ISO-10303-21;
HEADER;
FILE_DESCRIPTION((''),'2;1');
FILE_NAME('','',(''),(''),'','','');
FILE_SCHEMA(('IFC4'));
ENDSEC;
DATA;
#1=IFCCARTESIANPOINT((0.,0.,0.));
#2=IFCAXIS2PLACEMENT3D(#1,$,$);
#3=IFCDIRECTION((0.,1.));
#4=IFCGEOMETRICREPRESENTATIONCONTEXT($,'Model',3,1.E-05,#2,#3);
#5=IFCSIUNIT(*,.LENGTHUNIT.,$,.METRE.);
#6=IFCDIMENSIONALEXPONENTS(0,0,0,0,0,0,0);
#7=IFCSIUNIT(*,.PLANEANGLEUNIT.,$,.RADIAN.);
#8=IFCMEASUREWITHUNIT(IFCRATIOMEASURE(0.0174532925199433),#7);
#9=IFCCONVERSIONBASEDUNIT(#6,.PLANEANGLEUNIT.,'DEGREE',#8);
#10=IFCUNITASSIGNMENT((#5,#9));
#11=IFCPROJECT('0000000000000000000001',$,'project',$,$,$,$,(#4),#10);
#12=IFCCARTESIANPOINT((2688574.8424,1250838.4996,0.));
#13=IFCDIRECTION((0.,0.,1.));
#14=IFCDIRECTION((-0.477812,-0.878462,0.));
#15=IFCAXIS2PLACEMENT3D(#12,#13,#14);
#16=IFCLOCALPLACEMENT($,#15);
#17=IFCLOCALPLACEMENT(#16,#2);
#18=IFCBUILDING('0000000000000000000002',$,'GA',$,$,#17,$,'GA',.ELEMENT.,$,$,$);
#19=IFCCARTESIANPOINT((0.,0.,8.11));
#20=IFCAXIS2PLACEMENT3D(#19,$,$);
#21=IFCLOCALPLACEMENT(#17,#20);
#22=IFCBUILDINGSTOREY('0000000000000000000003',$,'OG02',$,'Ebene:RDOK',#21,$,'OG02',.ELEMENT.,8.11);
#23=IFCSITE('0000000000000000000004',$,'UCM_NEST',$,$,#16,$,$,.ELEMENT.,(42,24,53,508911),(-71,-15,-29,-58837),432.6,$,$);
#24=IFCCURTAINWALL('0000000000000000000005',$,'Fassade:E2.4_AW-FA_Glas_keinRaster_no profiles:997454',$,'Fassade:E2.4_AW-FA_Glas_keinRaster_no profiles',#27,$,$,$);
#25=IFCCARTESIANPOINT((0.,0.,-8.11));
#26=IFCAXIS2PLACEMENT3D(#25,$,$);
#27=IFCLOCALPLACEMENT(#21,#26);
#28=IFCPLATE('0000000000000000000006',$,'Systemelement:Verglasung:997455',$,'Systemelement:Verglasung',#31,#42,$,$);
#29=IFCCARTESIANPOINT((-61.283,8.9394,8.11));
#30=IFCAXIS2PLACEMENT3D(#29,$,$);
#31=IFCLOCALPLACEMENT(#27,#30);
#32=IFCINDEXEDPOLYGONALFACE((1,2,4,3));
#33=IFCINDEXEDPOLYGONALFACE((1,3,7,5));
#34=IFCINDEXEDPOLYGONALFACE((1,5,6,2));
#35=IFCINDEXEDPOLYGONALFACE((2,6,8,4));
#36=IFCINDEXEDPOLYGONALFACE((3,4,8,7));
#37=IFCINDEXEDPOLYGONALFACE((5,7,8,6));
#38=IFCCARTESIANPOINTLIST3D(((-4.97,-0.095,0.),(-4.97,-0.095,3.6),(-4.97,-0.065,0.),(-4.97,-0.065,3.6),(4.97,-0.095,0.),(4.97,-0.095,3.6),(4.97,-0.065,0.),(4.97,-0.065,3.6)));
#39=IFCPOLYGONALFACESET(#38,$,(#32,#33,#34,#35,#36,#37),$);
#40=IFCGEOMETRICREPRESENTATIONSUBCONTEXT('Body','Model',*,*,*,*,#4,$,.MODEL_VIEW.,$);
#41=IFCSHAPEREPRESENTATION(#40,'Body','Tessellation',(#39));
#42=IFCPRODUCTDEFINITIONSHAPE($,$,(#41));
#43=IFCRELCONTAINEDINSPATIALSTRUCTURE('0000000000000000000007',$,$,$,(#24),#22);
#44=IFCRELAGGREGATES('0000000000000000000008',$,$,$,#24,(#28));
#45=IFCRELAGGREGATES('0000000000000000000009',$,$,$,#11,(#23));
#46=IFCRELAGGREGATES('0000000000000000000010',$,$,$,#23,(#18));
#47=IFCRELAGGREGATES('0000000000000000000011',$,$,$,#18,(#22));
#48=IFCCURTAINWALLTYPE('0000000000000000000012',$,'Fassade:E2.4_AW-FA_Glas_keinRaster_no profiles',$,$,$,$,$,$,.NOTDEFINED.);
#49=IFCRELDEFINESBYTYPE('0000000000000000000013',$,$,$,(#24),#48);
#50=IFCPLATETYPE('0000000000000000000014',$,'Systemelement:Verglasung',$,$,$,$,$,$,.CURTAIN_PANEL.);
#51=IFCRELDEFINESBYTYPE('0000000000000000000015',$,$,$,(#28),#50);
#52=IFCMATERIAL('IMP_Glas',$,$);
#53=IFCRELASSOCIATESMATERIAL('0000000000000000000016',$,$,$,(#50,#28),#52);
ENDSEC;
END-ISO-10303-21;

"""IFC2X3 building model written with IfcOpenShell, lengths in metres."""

from ifc_helpers import new_model, entity, si_unit, converted_unit, direction, frame, frame_2d, origin, place, context, subcontext, project, spatial, rectangle, extrude, source, transform, mapped, material, type_object, type_shapes, element, aggregate, save


model = new_model("IFC2X3")

# Units and contexts
model_context = context("Model", 3, precision=1e-05, world=origin(), true_north=direction((0.0, 1.0)))
body_context = subcontext(model_context, "Body", "Model", "MODEL_VIEW")
ifc_project = project(units=[si_unit("LENGTHUNIT", "METRE"), converted_unit("PLANEANGLEUNIT", "DEGREE", entity("IfcRatioMeasure", 0.0174532925199433), si_unit("PLANEANGLEUNIT", "RADIAN"), dimensions=[0, 0, 0, 0, 0, 0, 0])], contexts=[model_context])

# Site, building, storey
site_placement = place(None, frame((2688574.8424, 1250838.4996, 0.0), z_axis=(0.0, 0.0, 1.0), x_axis=(-0.477812, -0.878462, 0.0)))
site = spatial("IfcSite", under=ifc_project, at=site_placement, Name="UCM_NEST", CompositionType="ELEMENT", RefLatitude=(42, 24, 53, 508911), RefLongitude=(-71, -15, -29, -58837), RefElevation=432.6)
building_placement = place(site_placement, origin())
building = spatial("IfcBuilding", under=site, at=building_placement, Name="GA", LongName="GA", CompositionType="ELEMENT")
storey_placement = place(building_placement, frame((0.0, 0.0, 8.11)))
storey = spatial("IfcBuildingStorey", under=building, at=storey_placement, Name="OG02", ObjectType="Ebene:RDOK", LongName="OG02", CompositionType="ELEMENT", Elevation=8.11)

# Curtain wall, plate
curtain_wall_type = type_object("IfcCurtainWallType", Name="Fassade:E2.4_AW-FA_Glas_keinRaster_no profiles", PredefinedType="NOTDEFINED")
curtain_wall_placement = place(storey_placement, frame((0.0, 0.0, -8.11)))
curtain_wall = element("IfcCurtainWall", 1, at=curtain_wall_placement, inside=storey, type_object=curtain_wall_type, Name="Fassade:E2.4_AW-FA_Glas_keinRaster_no profiles:997454", ObjectType="Fassade:E2.4_AW-FA_Glas_keinRaster_no profiles")
ifc_material_1 = material(Name="IMP_Glas")
plate_type = type_object("IfcPlateType", Name="Systemelement:Verglasung", PredefinedType="CURTAIN_PANEL", material=ifc_material_1)
shared_shape = source(origin(), body_context, "Body", "SweptSolid", [
    extrude(rectangle(XDim=0.03, YDim=9.94, at=frame_2d((0.0, 0.0), x_axis=(1.0, 0.0))), frame((0.0, -0.08, 0.0), z_axis=(0.0, 0.0, 1.0), x_axis=(0.0, 1.0, 0.0)), (0.0, 0.0, 1.0), 3.6),
])
type_shapes(plate_type, [shared_shape])
plate_placement = place(curtain_wall_placement, frame((-61.283, 8.9394, 8.11)))
plate = element("IfcPlate", 2, at=plate_placement, type_object=plate_type, material=ifc_material_1, Name="Systemelement:Verglasung:997455", ObjectType="Systemelement:Verglasung", context=body_context, shape_type="MappedRepresentation", body=[
    mapped(shared_shape, transform((0.0, 0.0, 0.0), scale=1.0)),
])
aggregate(curtain_wall, [plate])

save(model, "model.ifc")
